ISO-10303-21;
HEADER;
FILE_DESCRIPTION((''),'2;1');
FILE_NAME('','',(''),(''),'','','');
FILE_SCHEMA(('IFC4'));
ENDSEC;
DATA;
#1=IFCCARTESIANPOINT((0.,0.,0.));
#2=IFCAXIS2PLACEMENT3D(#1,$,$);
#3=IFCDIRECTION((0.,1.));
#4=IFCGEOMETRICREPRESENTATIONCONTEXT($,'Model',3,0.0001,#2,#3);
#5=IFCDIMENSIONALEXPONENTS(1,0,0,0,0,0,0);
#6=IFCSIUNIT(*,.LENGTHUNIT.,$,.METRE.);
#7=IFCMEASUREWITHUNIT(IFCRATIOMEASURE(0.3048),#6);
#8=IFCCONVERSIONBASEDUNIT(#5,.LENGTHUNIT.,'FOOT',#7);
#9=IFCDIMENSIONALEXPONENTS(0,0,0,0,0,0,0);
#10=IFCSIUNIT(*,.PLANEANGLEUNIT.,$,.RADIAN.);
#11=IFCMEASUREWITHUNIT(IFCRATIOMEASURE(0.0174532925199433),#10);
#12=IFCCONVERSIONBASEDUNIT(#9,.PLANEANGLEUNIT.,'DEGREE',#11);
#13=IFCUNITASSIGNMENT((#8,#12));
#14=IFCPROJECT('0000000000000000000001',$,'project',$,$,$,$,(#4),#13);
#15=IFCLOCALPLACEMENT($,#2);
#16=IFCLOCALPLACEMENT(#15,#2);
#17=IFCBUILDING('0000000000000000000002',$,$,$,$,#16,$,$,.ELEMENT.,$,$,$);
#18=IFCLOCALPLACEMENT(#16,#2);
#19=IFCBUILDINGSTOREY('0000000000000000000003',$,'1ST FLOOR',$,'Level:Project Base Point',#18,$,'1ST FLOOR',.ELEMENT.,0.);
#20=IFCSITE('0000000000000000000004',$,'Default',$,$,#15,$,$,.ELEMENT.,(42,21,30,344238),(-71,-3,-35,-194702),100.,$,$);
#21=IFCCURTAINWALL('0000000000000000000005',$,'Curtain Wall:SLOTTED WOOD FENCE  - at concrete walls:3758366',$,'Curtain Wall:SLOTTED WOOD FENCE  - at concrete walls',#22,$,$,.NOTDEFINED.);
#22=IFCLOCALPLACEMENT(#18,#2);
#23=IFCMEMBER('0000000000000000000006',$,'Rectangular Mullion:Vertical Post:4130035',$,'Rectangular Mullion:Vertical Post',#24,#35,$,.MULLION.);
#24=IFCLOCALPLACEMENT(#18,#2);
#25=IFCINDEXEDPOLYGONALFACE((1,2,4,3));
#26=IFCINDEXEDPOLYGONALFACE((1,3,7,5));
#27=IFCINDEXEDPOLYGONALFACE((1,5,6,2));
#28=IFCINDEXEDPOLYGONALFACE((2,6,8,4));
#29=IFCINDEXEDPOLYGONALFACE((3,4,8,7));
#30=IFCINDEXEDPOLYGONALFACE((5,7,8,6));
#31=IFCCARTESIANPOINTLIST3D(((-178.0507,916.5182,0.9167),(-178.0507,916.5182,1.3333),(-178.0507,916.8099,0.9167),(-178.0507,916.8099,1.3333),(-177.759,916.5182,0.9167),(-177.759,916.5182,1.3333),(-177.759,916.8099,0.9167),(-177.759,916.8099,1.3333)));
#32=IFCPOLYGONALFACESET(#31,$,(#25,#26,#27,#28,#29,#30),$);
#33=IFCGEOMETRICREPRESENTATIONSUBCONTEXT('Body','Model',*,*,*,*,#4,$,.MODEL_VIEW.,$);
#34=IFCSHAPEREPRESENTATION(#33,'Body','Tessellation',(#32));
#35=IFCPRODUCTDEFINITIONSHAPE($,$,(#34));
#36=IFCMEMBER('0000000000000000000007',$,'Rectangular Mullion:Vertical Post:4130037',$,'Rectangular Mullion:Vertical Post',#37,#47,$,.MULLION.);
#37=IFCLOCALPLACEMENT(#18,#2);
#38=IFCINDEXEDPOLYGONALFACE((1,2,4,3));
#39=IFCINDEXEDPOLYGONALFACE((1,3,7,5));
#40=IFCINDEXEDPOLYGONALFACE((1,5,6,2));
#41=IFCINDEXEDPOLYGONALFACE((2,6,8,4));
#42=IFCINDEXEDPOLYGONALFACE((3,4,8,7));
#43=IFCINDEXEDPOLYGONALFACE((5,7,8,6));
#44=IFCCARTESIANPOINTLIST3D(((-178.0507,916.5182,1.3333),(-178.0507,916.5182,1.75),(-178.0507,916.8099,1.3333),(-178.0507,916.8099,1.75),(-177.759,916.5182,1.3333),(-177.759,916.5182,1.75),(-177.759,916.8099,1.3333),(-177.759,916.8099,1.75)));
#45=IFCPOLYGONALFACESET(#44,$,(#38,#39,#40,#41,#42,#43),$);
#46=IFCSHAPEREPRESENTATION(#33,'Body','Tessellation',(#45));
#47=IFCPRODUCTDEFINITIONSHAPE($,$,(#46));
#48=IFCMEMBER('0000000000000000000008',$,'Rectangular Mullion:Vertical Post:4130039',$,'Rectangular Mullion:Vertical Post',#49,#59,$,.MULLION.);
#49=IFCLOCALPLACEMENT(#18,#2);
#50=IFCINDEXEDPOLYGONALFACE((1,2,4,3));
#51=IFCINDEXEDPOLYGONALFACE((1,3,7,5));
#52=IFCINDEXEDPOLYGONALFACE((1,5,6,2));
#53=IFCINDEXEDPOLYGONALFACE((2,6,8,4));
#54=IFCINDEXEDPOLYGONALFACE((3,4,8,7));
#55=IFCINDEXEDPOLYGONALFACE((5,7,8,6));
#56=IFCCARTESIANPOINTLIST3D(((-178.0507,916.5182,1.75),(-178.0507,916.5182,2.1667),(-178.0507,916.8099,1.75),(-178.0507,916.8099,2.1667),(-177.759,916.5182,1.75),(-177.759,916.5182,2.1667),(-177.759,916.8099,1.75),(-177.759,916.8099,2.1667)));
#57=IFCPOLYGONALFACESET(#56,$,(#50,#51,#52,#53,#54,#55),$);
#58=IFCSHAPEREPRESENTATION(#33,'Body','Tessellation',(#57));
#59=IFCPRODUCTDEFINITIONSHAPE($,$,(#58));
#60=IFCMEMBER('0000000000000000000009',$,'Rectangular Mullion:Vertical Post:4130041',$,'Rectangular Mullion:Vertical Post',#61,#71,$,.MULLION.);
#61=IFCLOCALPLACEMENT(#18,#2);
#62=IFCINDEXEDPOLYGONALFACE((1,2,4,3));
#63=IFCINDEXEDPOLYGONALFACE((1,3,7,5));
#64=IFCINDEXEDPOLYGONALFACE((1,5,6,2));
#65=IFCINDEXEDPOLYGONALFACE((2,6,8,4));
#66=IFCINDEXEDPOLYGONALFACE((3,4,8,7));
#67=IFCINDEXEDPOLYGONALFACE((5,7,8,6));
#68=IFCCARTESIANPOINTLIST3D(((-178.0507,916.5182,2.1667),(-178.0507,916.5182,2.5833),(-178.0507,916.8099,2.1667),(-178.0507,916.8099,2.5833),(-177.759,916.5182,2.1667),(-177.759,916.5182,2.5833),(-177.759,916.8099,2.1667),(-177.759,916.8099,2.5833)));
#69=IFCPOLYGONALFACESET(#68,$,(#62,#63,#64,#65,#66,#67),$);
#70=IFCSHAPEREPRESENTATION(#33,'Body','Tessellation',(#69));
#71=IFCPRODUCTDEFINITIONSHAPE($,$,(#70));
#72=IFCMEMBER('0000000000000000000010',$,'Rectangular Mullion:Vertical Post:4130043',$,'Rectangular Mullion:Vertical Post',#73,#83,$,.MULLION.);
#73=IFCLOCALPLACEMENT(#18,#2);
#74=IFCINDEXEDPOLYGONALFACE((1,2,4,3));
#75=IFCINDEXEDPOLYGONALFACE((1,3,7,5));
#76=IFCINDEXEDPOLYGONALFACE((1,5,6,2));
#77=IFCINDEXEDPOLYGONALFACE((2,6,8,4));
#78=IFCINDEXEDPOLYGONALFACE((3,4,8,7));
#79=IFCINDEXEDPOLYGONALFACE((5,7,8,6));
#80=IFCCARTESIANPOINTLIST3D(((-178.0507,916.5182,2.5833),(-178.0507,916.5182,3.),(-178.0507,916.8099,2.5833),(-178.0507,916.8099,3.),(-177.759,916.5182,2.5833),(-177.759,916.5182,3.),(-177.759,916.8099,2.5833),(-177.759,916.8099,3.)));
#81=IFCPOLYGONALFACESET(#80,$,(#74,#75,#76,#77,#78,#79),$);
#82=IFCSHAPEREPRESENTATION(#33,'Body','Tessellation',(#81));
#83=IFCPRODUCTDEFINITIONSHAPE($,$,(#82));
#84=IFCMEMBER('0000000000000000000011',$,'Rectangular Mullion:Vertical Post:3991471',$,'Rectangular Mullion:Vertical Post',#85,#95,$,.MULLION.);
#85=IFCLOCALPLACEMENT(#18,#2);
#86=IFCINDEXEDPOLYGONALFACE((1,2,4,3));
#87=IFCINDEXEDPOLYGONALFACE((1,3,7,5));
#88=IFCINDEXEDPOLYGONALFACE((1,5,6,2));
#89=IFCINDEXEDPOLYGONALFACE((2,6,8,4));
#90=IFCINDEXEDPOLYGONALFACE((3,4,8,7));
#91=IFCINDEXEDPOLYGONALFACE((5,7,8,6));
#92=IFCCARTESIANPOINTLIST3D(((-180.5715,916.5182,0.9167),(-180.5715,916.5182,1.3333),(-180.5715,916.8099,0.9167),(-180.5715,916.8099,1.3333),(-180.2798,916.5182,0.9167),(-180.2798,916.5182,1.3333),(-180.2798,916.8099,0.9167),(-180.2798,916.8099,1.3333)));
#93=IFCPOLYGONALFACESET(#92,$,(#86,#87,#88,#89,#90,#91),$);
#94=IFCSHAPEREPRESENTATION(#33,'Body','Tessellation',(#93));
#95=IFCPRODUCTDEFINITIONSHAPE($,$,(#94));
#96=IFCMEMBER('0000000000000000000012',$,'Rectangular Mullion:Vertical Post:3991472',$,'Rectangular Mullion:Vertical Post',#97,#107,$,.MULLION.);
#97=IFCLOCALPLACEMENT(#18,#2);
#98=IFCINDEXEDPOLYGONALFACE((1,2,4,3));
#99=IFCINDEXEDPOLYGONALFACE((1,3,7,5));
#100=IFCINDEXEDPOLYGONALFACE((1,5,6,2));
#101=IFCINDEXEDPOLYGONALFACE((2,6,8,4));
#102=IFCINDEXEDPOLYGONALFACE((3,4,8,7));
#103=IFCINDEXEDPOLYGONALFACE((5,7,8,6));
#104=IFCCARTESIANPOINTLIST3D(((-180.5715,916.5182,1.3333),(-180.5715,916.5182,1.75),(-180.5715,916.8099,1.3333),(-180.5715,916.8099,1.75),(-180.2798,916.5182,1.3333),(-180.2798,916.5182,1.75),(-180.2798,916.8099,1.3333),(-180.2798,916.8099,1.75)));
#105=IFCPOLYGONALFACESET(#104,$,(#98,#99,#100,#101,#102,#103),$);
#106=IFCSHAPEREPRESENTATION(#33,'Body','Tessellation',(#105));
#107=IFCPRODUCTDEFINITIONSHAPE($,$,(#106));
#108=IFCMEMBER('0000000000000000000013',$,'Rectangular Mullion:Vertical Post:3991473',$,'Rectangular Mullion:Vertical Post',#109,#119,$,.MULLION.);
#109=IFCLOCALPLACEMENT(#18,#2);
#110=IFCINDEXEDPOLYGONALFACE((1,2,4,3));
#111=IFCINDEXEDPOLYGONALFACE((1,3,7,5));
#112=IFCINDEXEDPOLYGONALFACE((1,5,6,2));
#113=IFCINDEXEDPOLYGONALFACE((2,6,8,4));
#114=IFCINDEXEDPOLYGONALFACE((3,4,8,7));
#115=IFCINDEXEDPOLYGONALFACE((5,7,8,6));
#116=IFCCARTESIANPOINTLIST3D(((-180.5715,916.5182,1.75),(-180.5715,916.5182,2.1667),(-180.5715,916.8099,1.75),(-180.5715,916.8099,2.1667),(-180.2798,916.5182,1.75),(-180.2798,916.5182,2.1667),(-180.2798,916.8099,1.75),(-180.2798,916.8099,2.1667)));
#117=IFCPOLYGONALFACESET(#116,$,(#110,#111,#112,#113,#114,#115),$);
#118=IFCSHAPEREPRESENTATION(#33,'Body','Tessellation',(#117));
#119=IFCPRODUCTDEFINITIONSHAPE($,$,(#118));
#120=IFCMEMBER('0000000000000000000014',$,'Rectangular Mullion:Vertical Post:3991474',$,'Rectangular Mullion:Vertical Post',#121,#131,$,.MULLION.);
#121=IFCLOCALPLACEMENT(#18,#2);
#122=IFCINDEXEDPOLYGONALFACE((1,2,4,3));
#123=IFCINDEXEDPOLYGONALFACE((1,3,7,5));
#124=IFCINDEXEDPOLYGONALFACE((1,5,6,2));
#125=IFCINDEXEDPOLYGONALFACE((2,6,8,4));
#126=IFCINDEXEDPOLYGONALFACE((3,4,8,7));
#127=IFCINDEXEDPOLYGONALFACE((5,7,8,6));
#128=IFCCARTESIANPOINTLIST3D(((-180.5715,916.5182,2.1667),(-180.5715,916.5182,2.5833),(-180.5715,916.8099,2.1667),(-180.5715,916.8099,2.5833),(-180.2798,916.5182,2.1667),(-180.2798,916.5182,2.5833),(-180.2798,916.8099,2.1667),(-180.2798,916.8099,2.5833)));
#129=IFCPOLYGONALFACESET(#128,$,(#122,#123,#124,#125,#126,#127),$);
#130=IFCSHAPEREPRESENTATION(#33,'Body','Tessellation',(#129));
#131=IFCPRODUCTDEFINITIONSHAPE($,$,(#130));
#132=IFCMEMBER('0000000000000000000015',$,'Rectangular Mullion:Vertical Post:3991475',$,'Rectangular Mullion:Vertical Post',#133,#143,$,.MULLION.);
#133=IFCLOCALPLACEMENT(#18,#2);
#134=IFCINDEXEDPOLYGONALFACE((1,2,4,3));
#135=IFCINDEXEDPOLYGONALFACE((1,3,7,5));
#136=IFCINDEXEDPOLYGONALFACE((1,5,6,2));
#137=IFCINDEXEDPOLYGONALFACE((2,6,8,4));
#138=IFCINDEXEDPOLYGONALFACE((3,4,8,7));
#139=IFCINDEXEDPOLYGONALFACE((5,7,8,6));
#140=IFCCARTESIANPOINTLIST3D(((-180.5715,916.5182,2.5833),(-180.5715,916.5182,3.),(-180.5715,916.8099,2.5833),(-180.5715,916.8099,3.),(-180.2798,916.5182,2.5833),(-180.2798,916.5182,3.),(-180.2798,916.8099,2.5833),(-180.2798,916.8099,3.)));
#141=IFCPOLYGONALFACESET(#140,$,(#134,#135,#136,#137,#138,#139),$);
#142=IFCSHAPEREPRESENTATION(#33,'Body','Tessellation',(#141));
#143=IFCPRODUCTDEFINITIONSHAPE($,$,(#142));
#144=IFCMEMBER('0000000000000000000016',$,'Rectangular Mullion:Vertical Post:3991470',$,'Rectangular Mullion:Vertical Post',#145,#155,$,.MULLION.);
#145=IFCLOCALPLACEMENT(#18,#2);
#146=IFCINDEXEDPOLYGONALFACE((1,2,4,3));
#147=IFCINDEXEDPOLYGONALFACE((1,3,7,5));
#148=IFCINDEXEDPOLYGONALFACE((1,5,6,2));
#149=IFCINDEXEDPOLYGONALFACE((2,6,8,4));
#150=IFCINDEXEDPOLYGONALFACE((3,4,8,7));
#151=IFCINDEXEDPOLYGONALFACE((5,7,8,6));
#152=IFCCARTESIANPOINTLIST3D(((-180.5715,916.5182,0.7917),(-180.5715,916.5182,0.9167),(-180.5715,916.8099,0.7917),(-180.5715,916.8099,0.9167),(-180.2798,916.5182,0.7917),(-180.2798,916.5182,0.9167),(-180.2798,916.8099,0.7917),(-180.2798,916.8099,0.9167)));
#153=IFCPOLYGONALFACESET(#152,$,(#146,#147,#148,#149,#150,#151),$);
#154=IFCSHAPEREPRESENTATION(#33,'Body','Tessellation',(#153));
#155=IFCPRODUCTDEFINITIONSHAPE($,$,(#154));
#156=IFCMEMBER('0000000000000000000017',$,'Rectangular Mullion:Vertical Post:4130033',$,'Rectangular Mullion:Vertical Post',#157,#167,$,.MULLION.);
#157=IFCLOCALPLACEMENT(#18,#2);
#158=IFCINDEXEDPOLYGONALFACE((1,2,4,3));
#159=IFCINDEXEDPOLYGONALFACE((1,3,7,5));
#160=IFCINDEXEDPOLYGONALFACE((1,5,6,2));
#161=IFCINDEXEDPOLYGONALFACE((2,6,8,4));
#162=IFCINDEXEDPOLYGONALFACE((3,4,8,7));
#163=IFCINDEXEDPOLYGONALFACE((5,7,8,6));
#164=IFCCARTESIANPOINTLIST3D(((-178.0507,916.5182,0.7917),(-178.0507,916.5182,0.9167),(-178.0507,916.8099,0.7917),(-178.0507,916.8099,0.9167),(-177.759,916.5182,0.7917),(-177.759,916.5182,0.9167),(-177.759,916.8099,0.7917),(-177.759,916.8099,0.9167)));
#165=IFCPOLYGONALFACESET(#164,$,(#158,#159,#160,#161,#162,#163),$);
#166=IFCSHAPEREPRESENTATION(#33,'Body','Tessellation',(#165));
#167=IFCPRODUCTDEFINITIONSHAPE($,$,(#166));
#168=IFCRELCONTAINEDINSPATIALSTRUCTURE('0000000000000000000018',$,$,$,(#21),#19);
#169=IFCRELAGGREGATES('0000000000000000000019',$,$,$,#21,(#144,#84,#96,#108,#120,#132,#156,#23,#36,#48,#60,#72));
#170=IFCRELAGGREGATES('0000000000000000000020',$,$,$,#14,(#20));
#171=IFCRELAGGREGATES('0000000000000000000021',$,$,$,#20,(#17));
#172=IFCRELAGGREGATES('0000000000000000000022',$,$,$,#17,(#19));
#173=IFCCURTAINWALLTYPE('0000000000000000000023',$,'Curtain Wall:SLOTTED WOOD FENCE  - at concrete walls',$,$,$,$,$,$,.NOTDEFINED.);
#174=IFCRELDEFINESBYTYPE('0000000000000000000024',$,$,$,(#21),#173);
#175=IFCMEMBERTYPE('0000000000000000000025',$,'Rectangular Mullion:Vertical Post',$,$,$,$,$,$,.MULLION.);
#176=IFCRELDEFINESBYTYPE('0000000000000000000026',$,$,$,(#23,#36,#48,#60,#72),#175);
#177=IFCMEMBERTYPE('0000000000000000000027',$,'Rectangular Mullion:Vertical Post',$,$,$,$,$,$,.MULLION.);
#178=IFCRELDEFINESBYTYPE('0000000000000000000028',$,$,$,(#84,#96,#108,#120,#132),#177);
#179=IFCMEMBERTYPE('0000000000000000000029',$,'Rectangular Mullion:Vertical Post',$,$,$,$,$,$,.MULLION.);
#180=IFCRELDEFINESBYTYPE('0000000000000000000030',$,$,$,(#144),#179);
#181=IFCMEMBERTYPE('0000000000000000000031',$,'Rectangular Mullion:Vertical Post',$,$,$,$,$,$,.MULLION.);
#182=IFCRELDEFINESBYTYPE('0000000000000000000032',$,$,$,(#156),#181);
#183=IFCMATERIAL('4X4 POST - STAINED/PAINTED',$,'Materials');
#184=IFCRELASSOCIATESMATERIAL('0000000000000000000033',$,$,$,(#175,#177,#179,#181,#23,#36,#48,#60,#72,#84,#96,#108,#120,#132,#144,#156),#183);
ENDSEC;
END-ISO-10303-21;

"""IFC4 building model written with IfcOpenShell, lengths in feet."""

from ifc_helpers import new_model, entity, si_unit, converted_unit, direction, frame, origin, origin_2d_with_axis, place, context, subcontext, project, spatial, rectangle, extrude, source, transform, mapped, material, material_profile, profile_set, profile_usage, type_object, type_shapes, element, aggregate, save


model = new_model("IFC4")

# Units and contexts
model_context = context("Model", 3, precision=0.0001, world=origin(), true_north=direction((0.0, 1.0)))
body_context = subcontext(model_context, "Body", "Model", "MODEL_VIEW")
ifc_project = project(units=[converted_unit("LENGTHUNIT", "FOOT", entity("IfcRatioMeasure", 0.3048), si_unit("LENGTHUNIT", "METRE"), dimensions=[1, 0, 0, 0, 0, 0, 0]), converted_unit("PLANEANGLEUNIT", "DEGREE", entity("IfcRatioMeasure", 0.0174532925199433), si_unit("PLANEANGLEUNIT", "RADIAN"), dimensions=[0, 0, 0, 0, 0, 0, 0])], contexts=[model_context])

# Site, building, storey
site_placement = place(None, origin())
site = spatial("IfcSite", under=ifc_project, at=site_placement, Name="Default", CompositionType="ELEMENT", RefLatitude=(42, 21, 30, 344238), RefLongitude=(-71, -3, -35, -194702), RefElevation=100.0)
building_placement = place(site_placement, origin())
building = spatial("IfcBuilding", under=site, at=building_placement, CompositionType="ELEMENT")
storey_placement = place(building_placement, origin())
storey = spatial("IfcBuildingStorey", under=building, at=storey_placement, Name="1ST FLOOR", ObjectType="Level:Project Base Point", LongName="1ST FLOOR", CompositionType="ELEMENT", Elevation=0.0)

# Curtain wall, members
curtain_wall_type = type_object("IfcCurtainWallType", Name="Curtain Wall:SLOTTED WOOD FENCE  - at concrete walls", PredefinedType="NOTDEFINED")
curtain_wall_placement = place(storey_placement, origin())
curtain_wall = element("IfcCurtainWall", 1, at=curtain_wall_placement, inside=storey, type_object=curtain_wall_type, Name="Curtain Wall:SLOTTED WOOD FENCE  - at concrete walls:3758366", ObjectType="Curtain Wall:SLOTTED WOOD FENCE  - at concrete walls", PredefinedType="NOTDEFINED")
ifc_material_1 = material(Name="4X4 POST - STAINED/PAINTED", Category="Materials")
ifc_material_profile = material_profile(ifc_material_1, rectangle(XDim=0.2917, YDim=0.2917, at=origin_2d_with_axis()), Name="Vertical Post")
ifc_profile_set = profile_set([ifc_material_profile], Name="Vertical Post")
ifc_profile_usage_1 = profile_usage(ifc_profile_set)
member_type_1 = type_object("IfcMemberType", Name="Rectangular Mullion:Vertical Post", PredefinedType="MULLION", material=ifc_profile_set)
shared_shape_1 = source(origin(), body_context, "Body", "SweptSolid", [
    extrude(rectangle(XDim=0.2917, YDim=0.2917, at=origin_2d_with_axis()), frame((0.0, -0.2083, -0.4167), z_axis=(0.0, 0.0, 1.0), x_axis=(0.0, -1.0, 0.0)), (0.0, 0.0, 1.0), 0.4167),
])
type_shapes(member_type_1, [shared_shape_1])
member_1_placement = place(storey_placement, frame((-177.9048, 916.4557, 0.9167), z_axis=(0.0, 0.0, -1.0), x_axis=(1.0, 0.0, 0.0)))
member_1 = element("IfcMember", 2, at=member_1_placement, type_object=member_type_1, material=ifc_profile_usage_1, Name="Rectangular Mullion:Vertical Post:4130035", ObjectType="Rectangular Mullion:Vertical Post", PredefinedType="MULLION", context=body_context, shape_type="MappedRepresentation", body=[
    mapped(shared_shape_1, transform((0.0, 0.0, 0.0), scale=1.0)),
])
ifc_profile_usage_2 = profile_usage(ifc_profile_set)
member_2_placement = place(storey_placement, frame((-177.9048, 916.4557, 1.3333), z_axis=(0.0, 0.0, -1.0), x_axis=(1.0, 0.0, 0.0)))
member_2 = element("IfcMember", 3, at=member_2_placement, type_object=member_type_1, material=ifc_profile_usage_2, Name="Rectangular Mullion:Vertical Post:4130037", ObjectType="Rectangular Mullion:Vertical Post", PredefinedType="MULLION", context=body_context, shape_type="MappedRepresentation", body=[
    mapped(shared_shape_1, transform((0.0, 0.0, 0.0), scale=1.0)),
])
ifc_profile_usage_3 = profile_usage(ifc_profile_set)
member_3_placement = place(storey_placement, frame((-177.9048, 916.4557, 1.75), z_axis=(0.0, 0.0, -1.0), x_axis=(1.0, 0.0, 0.0)))
member_3 = element("IfcMember", 4, at=member_3_placement, type_object=member_type_1, material=ifc_profile_usage_3, Name="Rectangular Mullion:Vertical Post:4130039", ObjectType="Rectangular Mullion:Vertical Post", PredefinedType="MULLION", context=body_context, shape_type="MappedRepresentation", body=[
    mapped(shared_shape_1, transform((0.0, 0.0, 0.0), scale=1.0)),
])
ifc_profile_usage_4 = profile_usage(ifc_profile_set)
member_4_placement = place(storey_placement, frame((-177.9048, 916.4557, 2.1667), z_axis=(0.0, 0.0, -1.0), x_axis=(1.0, 0.0, 0.0)))
member_4 = element("IfcMember", 5, at=member_4_placement, type_object=member_type_1, material=ifc_profile_usage_4, Name="Rectangular Mullion:Vertical Post:4130041", ObjectType="Rectangular Mullion:Vertical Post", PredefinedType="MULLION", context=body_context, shape_type="MappedRepresentation", body=[
    mapped(shared_shape_1, transform((0.0, 0.0, 0.0), scale=1.0)),
])
ifc_profile_usage_5 = profile_usage(ifc_profile_set)
member_5_placement = place(storey_placement, frame((-177.9048, 916.4557, 2.5833), z_axis=(0.0, 0.0, -1.0), x_axis=(1.0, 0.0, 0.0)))
member_5 = element("IfcMember", 6, at=member_5_placement, type_object=member_type_1, material=ifc_profile_usage_5, Name="Rectangular Mullion:Vertical Post:4130043", ObjectType="Rectangular Mullion:Vertical Post", PredefinedType="MULLION", context=body_context, shape_type="MappedRepresentation", body=[
    mapped(shared_shape_1, transform((0.0, 0.0, 0.0), scale=1.0)),
])
ifc_profile_usage_6 = profile_usage(ifc_profile_set)
member_type_2 = type_object("IfcMemberType", Name="Rectangular Mullion:Vertical Post", PredefinedType="MULLION", material=ifc_profile_set)
shared_shape_2 = source(origin(), body_context, "Body", "SweptSolid", [
    extrude(rectangle(XDim=0.2917, YDim=0.2917, at=origin_2d_with_axis()), frame((-0.1458, -0.2083, -0.4167), z_axis=(0.0, 0.0, 1.0), x_axis=(0.0, -1.0, 0.0)), (0.0, 0.0, 1.0), 0.4167),
])
type_shapes(member_type_2, [shared_shape_2])
member_6_placement = place(storey_placement, frame((-180.5715, 916.4557, 1.3333), z_axis=(0.0, 0.0, 1.0), x_axis=(-1.0, 0.0, 0.0)))
member_6 = element("IfcMember", 7, at=member_6_placement, type_object=member_type_2, material=ifc_profile_usage_6, Name="Rectangular Mullion:Vertical Post:3991471", ObjectType="Rectangular Mullion:Vertical Post", PredefinedType="MULLION", context=body_context, shape_type="MappedRepresentation", body=[
    mapped(shared_shape_2, transform((0.0, 0.0, 0.0), scale=1.0)),
])
ifc_profile_usage_7 = profile_usage(ifc_profile_set)
member_7_placement = place(storey_placement, frame((-180.5715, 916.4557, 1.75), z_axis=(0.0, 0.0, 1.0), x_axis=(-1.0, 0.0, 0.0)))
member_7 = element("IfcMember", 8, at=member_7_placement, type_object=member_type_2, material=ifc_profile_usage_7, Name="Rectangular Mullion:Vertical Post:3991472", ObjectType="Rectangular Mullion:Vertical Post", PredefinedType="MULLION", context=body_context, shape_type="MappedRepresentation", body=[
    mapped(shared_shape_2, transform((0.0, 0.0, 0.0), scale=1.0)),
])
ifc_profile_usage_8 = profile_usage(ifc_profile_set)
member_8_placement = place(storey_placement, frame((-180.5715, 916.4557, 2.1667), z_axis=(0.0, 0.0, 1.0), x_axis=(-1.0, 0.0, 0.0)))
member_8 = element("IfcMember", 9, at=member_8_placement, type_object=member_type_2, material=ifc_profile_usage_8, Name="Rectangular Mullion:Vertical Post:3991473", ObjectType="Rectangular Mullion:Vertical Post", PredefinedType="MULLION", context=body_context, shape_type="MappedRepresentation", body=[
    mapped(shared_shape_2, transform((0.0, 0.0, 0.0), scale=1.0)),
])
ifc_profile_usage_9 = profile_usage(ifc_profile_set)
member_9_placement = place(storey_placement, frame((-180.5715, 916.4557, 2.5833), z_axis=(0.0, 0.0, 1.0), x_axis=(-1.0, 0.0, 0.0)))
member_9 = element("IfcMember", 10, at=member_9_placement, type_object=member_type_2, material=ifc_profile_usage_9, Name="Rectangular Mullion:Vertical Post:3991474", ObjectType="Rectangular Mullion:Vertical Post", PredefinedType="MULLION", context=body_context, shape_type="MappedRepresentation", body=[
    mapped(shared_shape_2, transform((0.0, 0.0, 0.0), scale=1.0)),
])
ifc_profile_usage_10 = profile_usage(ifc_profile_set)
member_10_placement = place(storey_placement, frame((-180.5715, 916.4557, 3.0), z_axis=(0.0, 0.0, 1.0), x_axis=(-1.0, 0.0, 0.0)))
member_10 = element("IfcMember", 11, at=member_10_placement, type_object=member_type_2, material=ifc_profile_usage_10, Name="Rectangular Mullion:Vertical Post:3991475", ObjectType="Rectangular Mullion:Vertical Post", PredefinedType="MULLION", context=body_context, shape_type="MappedRepresentation", body=[
    mapped(shared_shape_2, transform((0.0, 0.0, 0.0), scale=1.0)),
])
ifc_profile_usage_11 = profile_usage(ifc_profile_set)
member_type_3 = type_object("IfcMemberType", Name="Rectangular Mullion:Vertical Post", PredefinedType="MULLION", material=ifc_profile_set)
shared_shape_3 = source(origin(), body_context, "Body", "SweptSolid", [
    extrude(rectangle(XDim=0.2917, YDim=0.2917, at=origin_2d_with_axis()), frame((-0.1458, -0.2083, -0.125), z_axis=(0.0, 0.0, 1.0), x_axis=(0.0, -1.0, 0.0)), (0.0, 0.0, 1.0), 0.125),
])
type_shapes(member_type_3, [shared_shape_3])
member_11_placement = place(storey_placement, frame((-180.5715, 916.4557, 0.9167), z_axis=(0.0, 0.0, 1.0), x_axis=(-1.0, 0.0, 0.0)))
member_11 = element("IfcMember", 12, at=member_11_placement, type_object=member_type_3, material=ifc_profile_usage_11, Name="Rectangular Mullion:Vertical Post:3991470", ObjectType="Rectangular Mullion:Vertical Post", PredefinedType="MULLION", context=body_context, shape_type="MappedRepresentation", body=[
    mapped(shared_shape_3, transform((0.0, 0.0, 0.0), scale=1.0)),
])
ifc_profile_usage_12 = profile_usage(ifc_profile_set)
member_type_4 = type_object("IfcMemberType", Name="Rectangular Mullion:Vertical Post", PredefinedType="MULLION", material=ifc_profile_set)
shared_shape_4 = source(origin(), body_context, "Body", "SweptSolid", [
    extrude(rectangle(XDim=0.2917, YDim=0.2917, at=origin_2d_with_axis()), frame((0.0, -0.2083, -0.125), z_axis=(0.0, 0.0, 1.0), x_axis=(0.0, -1.0, 0.0)), (0.0, 0.0, 1.0), 0.125),
])
type_shapes(member_type_4, [shared_shape_4])
member_12_placement = place(storey_placement, frame((-177.9048, 916.4557, 0.7917), z_axis=(0.0, 0.0, -1.0), x_axis=(1.0, 0.0, 0.0)))
member_12 = element("IfcMember", 13, at=member_12_placement, type_object=member_type_4, material=ifc_profile_usage_12, Name="Rectangular Mullion:Vertical Post:4130033", ObjectType="Rectangular Mullion:Vertical Post", PredefinedType="MULLION", context=body_context, shape_type="MappedRepresentation", body=[
    mapped(shared_shape_4, transform((0.0, 0.0, 0.0), scale=1.0)),
])
aggregate(curtain_wall, [member_11, member_6, member_7, member_8, member_9, member_10, member_12, member_1, member_2, member_3, member_4, member_5])

save(model, "model.ifc")
